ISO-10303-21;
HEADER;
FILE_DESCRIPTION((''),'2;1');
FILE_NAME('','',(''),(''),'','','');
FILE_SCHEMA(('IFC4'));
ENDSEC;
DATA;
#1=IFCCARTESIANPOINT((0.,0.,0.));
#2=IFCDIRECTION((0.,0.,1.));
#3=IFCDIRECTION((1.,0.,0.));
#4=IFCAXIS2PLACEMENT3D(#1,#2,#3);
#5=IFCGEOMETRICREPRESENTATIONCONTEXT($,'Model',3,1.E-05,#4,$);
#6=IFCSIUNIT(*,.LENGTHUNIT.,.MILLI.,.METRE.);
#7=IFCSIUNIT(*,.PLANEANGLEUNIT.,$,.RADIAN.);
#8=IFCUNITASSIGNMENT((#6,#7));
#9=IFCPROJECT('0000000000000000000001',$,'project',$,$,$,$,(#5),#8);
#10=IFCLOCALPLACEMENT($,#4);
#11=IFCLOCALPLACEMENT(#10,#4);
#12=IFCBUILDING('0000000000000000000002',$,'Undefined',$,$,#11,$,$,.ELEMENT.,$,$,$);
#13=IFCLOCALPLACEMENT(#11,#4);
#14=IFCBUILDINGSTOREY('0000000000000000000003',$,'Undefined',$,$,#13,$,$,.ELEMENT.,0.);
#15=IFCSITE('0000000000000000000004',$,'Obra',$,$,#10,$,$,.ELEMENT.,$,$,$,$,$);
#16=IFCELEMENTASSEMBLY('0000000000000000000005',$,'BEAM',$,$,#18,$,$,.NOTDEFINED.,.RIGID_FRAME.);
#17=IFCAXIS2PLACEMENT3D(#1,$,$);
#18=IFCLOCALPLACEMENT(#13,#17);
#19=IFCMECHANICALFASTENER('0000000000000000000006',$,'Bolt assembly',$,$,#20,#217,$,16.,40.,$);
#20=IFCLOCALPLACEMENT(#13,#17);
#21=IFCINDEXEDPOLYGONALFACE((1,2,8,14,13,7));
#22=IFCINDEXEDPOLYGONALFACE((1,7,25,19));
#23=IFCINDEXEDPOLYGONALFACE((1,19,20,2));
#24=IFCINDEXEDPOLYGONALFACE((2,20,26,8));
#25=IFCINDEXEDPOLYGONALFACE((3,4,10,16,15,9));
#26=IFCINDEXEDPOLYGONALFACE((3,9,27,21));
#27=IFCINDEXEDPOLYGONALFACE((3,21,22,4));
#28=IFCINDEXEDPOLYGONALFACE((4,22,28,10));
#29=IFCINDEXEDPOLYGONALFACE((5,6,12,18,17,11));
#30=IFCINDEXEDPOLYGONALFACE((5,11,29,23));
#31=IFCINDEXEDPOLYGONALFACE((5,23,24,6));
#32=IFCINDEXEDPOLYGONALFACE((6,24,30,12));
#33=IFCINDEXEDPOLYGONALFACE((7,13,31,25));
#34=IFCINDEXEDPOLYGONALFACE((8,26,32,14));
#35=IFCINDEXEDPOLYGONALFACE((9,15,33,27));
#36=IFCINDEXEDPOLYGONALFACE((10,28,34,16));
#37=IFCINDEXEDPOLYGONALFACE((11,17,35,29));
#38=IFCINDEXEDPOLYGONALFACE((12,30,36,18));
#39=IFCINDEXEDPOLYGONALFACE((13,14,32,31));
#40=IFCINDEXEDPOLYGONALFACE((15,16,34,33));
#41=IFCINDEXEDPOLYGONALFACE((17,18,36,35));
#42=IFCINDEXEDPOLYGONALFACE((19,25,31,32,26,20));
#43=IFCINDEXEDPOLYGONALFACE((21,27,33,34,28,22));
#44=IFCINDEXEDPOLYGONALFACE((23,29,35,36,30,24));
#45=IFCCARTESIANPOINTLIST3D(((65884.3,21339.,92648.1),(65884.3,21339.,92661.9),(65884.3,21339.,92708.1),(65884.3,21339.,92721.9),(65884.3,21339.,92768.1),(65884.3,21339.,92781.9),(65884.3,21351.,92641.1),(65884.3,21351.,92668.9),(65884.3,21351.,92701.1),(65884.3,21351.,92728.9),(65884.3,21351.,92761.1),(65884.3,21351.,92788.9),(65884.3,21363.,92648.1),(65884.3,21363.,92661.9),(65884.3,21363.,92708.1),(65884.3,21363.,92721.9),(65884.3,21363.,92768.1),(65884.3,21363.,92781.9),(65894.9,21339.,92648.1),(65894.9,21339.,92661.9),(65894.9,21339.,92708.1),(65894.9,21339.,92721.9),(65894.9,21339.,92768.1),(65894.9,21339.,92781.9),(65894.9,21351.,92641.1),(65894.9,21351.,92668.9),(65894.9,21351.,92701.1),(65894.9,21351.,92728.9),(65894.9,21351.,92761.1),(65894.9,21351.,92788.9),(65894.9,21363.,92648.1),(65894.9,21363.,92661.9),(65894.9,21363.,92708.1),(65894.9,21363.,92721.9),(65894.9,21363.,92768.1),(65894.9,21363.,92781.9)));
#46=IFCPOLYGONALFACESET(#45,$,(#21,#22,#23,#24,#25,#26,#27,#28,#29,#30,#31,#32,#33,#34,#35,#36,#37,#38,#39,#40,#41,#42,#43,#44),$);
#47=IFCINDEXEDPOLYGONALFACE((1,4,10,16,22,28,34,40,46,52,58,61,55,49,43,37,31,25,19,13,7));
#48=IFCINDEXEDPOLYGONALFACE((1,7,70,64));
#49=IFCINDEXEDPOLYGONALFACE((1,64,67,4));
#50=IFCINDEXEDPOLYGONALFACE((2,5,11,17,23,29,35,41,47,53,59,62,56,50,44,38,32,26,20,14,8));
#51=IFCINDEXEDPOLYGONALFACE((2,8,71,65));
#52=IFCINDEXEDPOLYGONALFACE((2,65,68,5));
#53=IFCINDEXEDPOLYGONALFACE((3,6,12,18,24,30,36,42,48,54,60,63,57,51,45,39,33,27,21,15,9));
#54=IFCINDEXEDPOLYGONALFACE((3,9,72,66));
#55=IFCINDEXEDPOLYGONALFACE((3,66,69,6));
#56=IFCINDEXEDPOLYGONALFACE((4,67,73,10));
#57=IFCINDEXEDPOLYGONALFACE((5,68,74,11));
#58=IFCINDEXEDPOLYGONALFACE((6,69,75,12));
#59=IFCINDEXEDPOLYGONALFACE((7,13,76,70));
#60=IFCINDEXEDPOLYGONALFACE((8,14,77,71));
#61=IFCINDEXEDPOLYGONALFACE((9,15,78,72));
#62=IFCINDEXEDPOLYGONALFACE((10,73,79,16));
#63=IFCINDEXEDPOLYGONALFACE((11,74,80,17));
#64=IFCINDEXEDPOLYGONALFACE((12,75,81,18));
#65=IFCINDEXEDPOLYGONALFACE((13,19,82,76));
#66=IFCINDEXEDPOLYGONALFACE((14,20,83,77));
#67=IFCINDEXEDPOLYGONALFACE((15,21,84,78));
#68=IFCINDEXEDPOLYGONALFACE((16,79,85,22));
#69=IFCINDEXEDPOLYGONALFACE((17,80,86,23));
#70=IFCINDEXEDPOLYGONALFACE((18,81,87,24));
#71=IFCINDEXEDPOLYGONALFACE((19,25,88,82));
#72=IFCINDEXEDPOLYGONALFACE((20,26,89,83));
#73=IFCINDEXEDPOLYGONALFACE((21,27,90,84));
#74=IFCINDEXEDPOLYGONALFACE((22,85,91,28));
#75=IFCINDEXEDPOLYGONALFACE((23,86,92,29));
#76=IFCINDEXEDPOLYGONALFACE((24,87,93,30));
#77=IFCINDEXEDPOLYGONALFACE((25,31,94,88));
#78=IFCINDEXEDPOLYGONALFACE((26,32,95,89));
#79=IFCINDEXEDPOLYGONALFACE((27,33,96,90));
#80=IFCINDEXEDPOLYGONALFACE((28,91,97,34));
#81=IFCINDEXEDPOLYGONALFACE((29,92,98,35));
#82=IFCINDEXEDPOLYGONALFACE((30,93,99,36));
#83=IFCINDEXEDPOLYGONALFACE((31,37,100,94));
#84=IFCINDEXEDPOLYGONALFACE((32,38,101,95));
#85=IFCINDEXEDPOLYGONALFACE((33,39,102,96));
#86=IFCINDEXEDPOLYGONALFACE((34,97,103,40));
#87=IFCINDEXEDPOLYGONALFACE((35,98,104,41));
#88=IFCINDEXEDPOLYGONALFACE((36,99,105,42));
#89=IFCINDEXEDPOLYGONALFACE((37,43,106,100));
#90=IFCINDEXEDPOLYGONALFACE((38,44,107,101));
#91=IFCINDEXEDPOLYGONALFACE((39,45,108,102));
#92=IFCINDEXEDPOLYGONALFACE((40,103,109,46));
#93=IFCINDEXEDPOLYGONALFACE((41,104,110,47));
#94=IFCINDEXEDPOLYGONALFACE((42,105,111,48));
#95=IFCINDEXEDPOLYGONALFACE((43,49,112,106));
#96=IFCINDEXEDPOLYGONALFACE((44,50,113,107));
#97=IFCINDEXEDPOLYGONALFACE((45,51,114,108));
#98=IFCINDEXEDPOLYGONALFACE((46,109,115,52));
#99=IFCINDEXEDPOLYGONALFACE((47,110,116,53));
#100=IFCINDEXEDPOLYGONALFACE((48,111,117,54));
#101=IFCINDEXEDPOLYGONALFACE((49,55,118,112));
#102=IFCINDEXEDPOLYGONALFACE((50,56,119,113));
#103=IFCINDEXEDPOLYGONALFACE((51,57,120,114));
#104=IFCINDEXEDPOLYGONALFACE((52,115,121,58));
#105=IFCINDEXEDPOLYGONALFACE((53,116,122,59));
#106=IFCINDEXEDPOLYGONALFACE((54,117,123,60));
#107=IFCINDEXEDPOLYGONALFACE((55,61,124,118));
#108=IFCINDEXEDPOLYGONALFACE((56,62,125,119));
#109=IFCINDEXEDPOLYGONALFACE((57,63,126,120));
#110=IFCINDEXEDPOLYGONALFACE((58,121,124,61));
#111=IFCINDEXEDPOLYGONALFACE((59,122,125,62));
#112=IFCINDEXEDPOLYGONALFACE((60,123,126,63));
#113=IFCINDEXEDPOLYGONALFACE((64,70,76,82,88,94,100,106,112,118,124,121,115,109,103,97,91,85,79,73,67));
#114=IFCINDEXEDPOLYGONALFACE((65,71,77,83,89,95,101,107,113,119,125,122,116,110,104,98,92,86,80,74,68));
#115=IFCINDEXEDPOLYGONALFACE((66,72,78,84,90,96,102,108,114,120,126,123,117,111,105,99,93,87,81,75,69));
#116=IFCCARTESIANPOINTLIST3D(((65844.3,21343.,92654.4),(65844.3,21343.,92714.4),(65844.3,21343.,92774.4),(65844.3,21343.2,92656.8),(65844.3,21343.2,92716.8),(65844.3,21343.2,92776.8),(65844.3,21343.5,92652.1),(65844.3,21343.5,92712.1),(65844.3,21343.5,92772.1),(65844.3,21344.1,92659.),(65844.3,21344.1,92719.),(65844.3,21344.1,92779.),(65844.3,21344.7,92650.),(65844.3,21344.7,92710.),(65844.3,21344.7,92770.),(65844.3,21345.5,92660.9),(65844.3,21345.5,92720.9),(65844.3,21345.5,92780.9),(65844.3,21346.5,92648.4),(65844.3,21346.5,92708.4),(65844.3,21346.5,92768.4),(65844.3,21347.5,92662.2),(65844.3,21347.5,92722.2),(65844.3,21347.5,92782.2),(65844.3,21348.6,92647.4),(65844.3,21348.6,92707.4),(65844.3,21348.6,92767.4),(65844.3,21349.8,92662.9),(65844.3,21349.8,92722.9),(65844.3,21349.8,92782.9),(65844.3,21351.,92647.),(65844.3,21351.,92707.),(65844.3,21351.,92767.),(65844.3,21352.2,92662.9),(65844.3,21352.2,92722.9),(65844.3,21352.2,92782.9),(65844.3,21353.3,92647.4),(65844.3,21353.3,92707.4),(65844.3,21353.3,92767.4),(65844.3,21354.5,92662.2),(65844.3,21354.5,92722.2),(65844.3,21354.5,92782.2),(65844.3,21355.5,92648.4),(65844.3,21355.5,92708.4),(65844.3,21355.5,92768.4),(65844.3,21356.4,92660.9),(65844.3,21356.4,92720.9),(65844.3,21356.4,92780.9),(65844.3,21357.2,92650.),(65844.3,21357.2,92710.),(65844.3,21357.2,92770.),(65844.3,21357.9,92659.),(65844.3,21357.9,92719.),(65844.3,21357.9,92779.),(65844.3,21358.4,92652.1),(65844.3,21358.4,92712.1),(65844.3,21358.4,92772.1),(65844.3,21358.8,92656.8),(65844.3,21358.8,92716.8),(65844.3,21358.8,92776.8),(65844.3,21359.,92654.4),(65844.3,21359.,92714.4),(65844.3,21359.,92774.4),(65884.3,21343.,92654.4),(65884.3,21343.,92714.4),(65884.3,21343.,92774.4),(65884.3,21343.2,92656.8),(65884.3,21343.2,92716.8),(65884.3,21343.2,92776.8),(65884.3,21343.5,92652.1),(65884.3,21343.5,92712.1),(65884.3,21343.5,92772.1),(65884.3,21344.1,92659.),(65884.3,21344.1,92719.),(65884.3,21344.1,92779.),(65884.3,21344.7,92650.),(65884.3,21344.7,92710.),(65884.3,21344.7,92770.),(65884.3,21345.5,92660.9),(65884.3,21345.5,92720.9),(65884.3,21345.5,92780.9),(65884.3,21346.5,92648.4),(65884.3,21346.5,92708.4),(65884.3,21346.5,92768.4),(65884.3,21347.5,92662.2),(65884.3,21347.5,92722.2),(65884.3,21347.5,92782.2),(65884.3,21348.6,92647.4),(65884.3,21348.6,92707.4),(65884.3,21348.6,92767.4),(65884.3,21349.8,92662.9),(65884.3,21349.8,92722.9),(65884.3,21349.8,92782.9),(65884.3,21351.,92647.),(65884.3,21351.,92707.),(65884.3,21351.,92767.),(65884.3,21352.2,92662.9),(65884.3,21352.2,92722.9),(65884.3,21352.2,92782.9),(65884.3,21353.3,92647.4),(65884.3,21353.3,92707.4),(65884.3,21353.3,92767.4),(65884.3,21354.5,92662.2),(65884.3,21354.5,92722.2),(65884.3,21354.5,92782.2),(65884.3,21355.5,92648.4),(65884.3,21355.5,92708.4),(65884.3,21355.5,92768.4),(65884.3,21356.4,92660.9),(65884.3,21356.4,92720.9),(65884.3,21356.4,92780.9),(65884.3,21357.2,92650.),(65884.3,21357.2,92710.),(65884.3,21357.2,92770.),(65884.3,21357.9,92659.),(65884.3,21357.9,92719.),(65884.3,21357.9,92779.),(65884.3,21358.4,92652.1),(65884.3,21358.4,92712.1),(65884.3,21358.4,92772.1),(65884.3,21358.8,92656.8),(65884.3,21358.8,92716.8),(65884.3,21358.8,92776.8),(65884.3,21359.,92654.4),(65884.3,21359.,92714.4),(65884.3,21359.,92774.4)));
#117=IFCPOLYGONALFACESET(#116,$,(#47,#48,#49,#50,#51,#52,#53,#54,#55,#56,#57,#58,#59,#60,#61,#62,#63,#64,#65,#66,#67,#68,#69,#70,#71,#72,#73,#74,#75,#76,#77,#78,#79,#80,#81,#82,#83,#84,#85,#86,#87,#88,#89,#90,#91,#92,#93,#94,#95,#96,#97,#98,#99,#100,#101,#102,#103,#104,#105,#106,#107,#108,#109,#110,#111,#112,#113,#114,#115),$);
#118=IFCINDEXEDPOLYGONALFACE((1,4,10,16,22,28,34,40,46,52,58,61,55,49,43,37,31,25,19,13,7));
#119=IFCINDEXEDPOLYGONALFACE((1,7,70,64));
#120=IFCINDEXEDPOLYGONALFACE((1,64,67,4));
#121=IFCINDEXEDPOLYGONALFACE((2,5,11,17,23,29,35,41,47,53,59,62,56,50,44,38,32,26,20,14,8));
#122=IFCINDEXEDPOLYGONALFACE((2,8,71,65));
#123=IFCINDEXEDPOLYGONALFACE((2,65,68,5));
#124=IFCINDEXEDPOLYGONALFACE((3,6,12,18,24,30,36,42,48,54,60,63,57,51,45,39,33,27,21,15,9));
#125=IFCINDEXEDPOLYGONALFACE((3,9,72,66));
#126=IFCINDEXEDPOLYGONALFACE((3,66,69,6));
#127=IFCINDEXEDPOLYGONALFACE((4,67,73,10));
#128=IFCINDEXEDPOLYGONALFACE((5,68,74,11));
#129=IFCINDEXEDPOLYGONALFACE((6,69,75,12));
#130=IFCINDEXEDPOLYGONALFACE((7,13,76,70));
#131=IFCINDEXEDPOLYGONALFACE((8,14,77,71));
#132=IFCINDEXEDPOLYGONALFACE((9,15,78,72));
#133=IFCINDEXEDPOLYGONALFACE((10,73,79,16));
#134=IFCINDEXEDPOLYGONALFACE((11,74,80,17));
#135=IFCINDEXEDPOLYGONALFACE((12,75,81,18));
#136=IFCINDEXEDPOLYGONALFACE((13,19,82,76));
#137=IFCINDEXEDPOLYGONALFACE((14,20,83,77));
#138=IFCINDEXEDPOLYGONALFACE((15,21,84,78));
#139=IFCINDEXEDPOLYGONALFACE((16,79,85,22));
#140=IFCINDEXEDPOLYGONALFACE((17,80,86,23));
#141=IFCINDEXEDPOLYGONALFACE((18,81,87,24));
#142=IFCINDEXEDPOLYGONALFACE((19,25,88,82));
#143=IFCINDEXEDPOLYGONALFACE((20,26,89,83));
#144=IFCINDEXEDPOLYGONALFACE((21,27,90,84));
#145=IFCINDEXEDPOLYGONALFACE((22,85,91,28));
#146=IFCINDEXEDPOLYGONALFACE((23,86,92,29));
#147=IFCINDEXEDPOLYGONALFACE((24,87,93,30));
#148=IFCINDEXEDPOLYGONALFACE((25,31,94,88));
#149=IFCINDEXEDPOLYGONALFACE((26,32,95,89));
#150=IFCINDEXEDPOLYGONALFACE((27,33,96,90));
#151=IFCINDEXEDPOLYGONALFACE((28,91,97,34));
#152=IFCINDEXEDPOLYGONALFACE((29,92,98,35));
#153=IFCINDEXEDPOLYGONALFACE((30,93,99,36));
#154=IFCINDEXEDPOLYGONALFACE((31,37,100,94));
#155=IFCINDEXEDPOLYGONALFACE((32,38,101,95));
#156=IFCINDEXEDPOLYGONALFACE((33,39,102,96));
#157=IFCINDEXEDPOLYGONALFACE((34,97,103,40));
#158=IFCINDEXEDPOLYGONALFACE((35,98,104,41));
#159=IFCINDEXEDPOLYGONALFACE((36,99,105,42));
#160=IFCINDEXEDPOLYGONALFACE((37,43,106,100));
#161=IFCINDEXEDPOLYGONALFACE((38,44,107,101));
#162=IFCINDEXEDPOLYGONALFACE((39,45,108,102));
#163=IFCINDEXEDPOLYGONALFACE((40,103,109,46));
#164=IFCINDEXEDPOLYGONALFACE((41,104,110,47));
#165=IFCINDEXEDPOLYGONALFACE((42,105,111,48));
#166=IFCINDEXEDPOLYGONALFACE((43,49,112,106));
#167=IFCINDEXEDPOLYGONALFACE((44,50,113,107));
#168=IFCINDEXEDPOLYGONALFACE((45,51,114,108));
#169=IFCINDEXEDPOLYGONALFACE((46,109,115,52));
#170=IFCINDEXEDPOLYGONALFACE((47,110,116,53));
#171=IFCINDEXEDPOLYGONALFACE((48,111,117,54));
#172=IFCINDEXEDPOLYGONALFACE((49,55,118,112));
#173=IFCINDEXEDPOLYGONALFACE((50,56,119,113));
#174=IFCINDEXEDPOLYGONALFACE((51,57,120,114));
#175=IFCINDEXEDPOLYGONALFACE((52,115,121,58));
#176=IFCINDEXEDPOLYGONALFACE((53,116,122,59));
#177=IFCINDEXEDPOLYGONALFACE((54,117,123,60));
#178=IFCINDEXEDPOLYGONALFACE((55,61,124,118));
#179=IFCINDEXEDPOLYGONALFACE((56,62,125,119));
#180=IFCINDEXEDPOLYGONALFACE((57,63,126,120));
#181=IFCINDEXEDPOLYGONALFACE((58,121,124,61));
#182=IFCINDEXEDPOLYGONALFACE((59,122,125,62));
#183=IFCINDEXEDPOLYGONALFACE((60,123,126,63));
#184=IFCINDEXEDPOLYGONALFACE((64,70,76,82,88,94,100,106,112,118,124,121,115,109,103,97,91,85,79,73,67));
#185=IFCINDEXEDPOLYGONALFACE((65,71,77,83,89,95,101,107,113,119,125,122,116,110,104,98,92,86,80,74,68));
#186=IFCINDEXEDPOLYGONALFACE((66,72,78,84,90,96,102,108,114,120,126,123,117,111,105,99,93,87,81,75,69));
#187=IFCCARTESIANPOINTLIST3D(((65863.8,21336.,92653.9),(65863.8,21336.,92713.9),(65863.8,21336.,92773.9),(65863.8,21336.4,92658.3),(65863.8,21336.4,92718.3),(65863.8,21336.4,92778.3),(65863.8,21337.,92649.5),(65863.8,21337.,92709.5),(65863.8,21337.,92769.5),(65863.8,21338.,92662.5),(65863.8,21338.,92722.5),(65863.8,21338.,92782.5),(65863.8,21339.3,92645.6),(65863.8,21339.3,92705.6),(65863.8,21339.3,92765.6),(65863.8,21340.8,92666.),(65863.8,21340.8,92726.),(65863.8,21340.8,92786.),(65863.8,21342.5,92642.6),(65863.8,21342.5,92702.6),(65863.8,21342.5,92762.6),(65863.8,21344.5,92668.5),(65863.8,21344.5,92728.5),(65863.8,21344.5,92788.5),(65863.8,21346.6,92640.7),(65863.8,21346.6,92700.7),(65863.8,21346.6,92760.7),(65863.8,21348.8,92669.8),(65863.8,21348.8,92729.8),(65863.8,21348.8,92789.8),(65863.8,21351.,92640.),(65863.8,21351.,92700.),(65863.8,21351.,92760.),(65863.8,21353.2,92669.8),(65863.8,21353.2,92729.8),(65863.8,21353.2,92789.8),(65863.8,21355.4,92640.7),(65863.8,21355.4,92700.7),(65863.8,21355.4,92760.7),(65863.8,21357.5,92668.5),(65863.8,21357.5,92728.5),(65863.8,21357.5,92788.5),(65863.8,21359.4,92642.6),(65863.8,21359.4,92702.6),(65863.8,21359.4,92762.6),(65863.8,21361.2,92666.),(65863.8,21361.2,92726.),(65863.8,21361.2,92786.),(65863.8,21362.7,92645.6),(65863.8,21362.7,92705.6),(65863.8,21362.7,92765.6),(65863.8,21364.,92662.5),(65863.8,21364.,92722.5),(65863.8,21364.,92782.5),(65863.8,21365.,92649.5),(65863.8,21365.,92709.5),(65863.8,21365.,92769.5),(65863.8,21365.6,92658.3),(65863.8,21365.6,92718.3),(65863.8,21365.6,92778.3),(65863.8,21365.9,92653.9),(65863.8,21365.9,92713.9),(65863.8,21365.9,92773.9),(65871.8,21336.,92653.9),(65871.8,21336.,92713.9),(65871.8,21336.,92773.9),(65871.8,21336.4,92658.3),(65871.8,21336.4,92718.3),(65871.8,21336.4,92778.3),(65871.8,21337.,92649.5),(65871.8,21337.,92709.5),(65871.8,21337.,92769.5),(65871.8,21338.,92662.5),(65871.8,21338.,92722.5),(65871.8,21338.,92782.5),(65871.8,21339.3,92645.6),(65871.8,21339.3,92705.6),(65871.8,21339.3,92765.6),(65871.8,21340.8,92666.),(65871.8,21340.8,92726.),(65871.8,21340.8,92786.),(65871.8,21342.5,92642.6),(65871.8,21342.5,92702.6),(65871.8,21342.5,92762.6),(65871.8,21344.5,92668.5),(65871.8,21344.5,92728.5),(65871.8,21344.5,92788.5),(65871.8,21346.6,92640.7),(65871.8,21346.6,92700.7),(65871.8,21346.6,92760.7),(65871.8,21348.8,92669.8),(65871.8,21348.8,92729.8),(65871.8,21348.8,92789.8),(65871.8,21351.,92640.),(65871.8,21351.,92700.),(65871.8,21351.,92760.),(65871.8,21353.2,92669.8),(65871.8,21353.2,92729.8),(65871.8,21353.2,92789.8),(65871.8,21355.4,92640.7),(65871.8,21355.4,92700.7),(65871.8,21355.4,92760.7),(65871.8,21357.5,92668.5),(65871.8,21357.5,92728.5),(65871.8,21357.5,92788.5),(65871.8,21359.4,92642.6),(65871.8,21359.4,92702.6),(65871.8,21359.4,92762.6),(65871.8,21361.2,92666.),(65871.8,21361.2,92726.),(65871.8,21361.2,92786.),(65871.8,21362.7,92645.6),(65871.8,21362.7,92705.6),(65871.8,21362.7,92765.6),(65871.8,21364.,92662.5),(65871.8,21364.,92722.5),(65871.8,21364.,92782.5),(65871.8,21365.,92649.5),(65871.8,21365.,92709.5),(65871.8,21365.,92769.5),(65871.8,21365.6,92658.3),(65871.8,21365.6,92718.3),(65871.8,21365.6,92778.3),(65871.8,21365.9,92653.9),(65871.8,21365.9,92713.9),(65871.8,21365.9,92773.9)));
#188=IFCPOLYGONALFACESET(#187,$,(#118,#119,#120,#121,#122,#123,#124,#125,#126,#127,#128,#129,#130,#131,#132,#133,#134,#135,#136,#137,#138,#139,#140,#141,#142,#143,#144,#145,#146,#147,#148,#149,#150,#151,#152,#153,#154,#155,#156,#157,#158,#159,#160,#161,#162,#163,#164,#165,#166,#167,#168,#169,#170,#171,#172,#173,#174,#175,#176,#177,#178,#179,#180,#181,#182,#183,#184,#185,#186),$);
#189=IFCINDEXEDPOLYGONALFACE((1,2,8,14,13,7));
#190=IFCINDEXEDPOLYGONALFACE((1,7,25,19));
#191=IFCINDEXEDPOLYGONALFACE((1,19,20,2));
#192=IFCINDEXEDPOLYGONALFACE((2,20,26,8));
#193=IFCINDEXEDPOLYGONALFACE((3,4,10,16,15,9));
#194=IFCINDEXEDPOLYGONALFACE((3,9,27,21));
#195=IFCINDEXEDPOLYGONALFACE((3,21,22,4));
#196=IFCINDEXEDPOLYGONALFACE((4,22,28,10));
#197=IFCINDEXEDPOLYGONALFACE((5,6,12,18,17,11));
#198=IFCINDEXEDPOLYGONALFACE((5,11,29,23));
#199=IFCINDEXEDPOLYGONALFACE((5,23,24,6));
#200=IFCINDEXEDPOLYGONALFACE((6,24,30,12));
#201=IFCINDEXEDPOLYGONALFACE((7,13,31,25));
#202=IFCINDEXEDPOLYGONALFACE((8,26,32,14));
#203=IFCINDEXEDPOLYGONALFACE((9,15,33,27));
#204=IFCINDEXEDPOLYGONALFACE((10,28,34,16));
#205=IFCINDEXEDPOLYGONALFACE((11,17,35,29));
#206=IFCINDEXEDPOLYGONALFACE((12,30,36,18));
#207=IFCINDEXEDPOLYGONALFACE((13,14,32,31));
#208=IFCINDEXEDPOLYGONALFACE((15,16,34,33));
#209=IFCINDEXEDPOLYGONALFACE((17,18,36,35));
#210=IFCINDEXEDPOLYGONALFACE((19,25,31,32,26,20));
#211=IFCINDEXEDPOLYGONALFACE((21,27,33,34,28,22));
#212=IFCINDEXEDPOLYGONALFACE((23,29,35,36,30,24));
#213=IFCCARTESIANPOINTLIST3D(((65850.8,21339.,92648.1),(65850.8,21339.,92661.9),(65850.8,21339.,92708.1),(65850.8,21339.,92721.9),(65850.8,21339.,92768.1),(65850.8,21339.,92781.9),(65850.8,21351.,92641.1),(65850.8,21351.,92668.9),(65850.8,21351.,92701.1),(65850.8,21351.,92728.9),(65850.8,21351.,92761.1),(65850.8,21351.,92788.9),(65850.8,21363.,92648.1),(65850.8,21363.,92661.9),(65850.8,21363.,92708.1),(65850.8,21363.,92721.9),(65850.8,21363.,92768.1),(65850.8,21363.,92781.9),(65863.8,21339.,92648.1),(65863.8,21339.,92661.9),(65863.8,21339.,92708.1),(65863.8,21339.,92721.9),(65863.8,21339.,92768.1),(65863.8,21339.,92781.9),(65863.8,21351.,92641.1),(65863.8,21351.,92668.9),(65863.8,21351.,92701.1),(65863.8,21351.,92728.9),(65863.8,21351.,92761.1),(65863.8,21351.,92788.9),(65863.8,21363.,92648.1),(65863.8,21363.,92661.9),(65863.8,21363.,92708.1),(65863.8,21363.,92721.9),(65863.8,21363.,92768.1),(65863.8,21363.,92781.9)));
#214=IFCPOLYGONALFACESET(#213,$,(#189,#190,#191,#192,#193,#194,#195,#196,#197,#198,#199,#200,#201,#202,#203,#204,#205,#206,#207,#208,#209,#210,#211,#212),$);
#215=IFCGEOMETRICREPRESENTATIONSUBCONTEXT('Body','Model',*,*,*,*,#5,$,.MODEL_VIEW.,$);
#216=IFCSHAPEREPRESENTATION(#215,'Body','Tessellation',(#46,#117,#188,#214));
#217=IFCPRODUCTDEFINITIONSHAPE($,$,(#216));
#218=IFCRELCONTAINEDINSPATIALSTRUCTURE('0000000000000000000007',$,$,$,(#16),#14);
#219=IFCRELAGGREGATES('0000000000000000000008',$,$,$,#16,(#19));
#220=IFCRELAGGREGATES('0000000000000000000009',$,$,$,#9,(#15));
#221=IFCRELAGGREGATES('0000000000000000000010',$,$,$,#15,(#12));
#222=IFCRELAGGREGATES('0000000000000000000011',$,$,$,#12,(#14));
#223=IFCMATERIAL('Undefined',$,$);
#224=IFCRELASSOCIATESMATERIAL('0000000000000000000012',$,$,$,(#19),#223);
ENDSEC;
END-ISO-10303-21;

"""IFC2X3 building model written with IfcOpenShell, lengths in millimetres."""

from ifc_helpers import new_model, si_unit, frame, origin_with_axes, origin_2d_with_axis, place, context, subcontext, project, spatial, polyline, circle, outline, extrude, source, transform, mapped, material, element, aggregate, save


model = new_model("IFC2X3")

# Units and contexts
model_context = context("Model", 3, precision=1e-05, world=origin_with_axes())
body_context = subcontext(model_context, "Body", "Model", "MODEL_VIEW")
ifc_project = project(units=[si_unit("LENGTHUNIT", "METRE", prefix="MILLI"), si_unit("PLANEANGLEUNIT", "RADIAN")], contexts=[model_context])

# Site, building, storey
site_placement = place(None, origin_with_axes())
site = spatial("IfcSite", under=ifc_project, at=site_placement, Name="Obra", CompositionType="ELEMENT")
building_placement = place(site_placement, origin_with_axes())
building = spatial("IfcBuilding", under=site, at=building_placement, Name="Undefined", CompositionType="ELEMENT")
storey_placement = place(building_placement, origin_with_axes())
storey = spatial("IfcBuildingStorey", under=building, at=storey_placement, Name="Undefined", CompositionType="ELEMENT", Elevation=0.0)

# Shared definitions
ifc_material_1 = material(Name="Undefined")

# Element assembly, mechanical fastener
assembly_1_placement = place(storey_placement, origin_with_axes())
assembly_1 = element("IfcElementAssembly", 1, at=assembly_1_placement, inside=storey, Name="BEAM", AssemblyPlace="NOTDEFINED", PredefinedType="RIGID_FRAME")
shared_shape_1 = source(origin_with_axes(), body_context, "Body", "SweptSolid", [
    extrude(outline(polyline([(13.9, 0.0), (6.9, 12.0), (-6.9, 12.0), (-13.9, 0.0), (-6.9, -12.0), (6.9, -12.0), (13.9, 0.0)])), frame((0.0, -19.9, 0.0), z_axis=(0.0, 1.0, 0.0), x_axis=(1.0, 0.0, 0.0)), (0.0, 0.0, 1.0), 10.6),
    extrude(circle(Radius=8.0, at=origin_2d_with_axis()), frame((0.0, -9.3, 0.0), z_axis=(0.0, 1.0, 0.0), x_axis=(1.0, 0.0, 0.0)), (0.0, 0.0, 1.0), 40.0),
    extrude(circle(Radius=15.0, at=origin_2d_with_axis()), frame((0.0, 3.2, 0.0), z_axis=(0.0, 1.0, 0.0), x_axis=(1.0, 0.0, 0.0)), (0.0, 0.0, 1.0), 8.0),
    extrude(outline(polyline([(13.9, 0.0), (6.9, 12.0), (-6.9, 12.0), (-13.9, 0.0), (-6.9, -12.0), (6.9, -12.0), (13.9, 0.0)])), frame((0.0, 11.2, 0.0), z_axis=(0.0, 1.0, 0.0), x_axis=(1.0, 0.0, 0.0)), (0.0, 0.0, 1.0), 13.0),
])
mechanical_fastener_1_placement = place(assembly_1_placement, frame((65875.0, 21301.0, 92850.0), z_axis=(-0.000002, 1.0, 0.0), x_axis=(0.0, 0.0, -1.0)))
mechanical_fastener_1 = element("IfcMechanicalFastener", 2, at=mechanical_fastener_1_placement, material=ifc_material_1, Name="Bolt assembly", NominalDiameter=16.0, NominalLength=40.0, context=body_context, shape_type="MappedRepresentation", body=[
    mapped(shared_shape_1, transform((75.0, 0.0, 50.0))),
    mapped(shared_shape_1, transform((135.0, 0.0, 50.0))),
    mapped(shared_shape_1, transform((195.0, 0.0, 50.0))),
])
aggregate(assembly_1, [mechanical_fastener_1])

save(model, "model.ifc")
